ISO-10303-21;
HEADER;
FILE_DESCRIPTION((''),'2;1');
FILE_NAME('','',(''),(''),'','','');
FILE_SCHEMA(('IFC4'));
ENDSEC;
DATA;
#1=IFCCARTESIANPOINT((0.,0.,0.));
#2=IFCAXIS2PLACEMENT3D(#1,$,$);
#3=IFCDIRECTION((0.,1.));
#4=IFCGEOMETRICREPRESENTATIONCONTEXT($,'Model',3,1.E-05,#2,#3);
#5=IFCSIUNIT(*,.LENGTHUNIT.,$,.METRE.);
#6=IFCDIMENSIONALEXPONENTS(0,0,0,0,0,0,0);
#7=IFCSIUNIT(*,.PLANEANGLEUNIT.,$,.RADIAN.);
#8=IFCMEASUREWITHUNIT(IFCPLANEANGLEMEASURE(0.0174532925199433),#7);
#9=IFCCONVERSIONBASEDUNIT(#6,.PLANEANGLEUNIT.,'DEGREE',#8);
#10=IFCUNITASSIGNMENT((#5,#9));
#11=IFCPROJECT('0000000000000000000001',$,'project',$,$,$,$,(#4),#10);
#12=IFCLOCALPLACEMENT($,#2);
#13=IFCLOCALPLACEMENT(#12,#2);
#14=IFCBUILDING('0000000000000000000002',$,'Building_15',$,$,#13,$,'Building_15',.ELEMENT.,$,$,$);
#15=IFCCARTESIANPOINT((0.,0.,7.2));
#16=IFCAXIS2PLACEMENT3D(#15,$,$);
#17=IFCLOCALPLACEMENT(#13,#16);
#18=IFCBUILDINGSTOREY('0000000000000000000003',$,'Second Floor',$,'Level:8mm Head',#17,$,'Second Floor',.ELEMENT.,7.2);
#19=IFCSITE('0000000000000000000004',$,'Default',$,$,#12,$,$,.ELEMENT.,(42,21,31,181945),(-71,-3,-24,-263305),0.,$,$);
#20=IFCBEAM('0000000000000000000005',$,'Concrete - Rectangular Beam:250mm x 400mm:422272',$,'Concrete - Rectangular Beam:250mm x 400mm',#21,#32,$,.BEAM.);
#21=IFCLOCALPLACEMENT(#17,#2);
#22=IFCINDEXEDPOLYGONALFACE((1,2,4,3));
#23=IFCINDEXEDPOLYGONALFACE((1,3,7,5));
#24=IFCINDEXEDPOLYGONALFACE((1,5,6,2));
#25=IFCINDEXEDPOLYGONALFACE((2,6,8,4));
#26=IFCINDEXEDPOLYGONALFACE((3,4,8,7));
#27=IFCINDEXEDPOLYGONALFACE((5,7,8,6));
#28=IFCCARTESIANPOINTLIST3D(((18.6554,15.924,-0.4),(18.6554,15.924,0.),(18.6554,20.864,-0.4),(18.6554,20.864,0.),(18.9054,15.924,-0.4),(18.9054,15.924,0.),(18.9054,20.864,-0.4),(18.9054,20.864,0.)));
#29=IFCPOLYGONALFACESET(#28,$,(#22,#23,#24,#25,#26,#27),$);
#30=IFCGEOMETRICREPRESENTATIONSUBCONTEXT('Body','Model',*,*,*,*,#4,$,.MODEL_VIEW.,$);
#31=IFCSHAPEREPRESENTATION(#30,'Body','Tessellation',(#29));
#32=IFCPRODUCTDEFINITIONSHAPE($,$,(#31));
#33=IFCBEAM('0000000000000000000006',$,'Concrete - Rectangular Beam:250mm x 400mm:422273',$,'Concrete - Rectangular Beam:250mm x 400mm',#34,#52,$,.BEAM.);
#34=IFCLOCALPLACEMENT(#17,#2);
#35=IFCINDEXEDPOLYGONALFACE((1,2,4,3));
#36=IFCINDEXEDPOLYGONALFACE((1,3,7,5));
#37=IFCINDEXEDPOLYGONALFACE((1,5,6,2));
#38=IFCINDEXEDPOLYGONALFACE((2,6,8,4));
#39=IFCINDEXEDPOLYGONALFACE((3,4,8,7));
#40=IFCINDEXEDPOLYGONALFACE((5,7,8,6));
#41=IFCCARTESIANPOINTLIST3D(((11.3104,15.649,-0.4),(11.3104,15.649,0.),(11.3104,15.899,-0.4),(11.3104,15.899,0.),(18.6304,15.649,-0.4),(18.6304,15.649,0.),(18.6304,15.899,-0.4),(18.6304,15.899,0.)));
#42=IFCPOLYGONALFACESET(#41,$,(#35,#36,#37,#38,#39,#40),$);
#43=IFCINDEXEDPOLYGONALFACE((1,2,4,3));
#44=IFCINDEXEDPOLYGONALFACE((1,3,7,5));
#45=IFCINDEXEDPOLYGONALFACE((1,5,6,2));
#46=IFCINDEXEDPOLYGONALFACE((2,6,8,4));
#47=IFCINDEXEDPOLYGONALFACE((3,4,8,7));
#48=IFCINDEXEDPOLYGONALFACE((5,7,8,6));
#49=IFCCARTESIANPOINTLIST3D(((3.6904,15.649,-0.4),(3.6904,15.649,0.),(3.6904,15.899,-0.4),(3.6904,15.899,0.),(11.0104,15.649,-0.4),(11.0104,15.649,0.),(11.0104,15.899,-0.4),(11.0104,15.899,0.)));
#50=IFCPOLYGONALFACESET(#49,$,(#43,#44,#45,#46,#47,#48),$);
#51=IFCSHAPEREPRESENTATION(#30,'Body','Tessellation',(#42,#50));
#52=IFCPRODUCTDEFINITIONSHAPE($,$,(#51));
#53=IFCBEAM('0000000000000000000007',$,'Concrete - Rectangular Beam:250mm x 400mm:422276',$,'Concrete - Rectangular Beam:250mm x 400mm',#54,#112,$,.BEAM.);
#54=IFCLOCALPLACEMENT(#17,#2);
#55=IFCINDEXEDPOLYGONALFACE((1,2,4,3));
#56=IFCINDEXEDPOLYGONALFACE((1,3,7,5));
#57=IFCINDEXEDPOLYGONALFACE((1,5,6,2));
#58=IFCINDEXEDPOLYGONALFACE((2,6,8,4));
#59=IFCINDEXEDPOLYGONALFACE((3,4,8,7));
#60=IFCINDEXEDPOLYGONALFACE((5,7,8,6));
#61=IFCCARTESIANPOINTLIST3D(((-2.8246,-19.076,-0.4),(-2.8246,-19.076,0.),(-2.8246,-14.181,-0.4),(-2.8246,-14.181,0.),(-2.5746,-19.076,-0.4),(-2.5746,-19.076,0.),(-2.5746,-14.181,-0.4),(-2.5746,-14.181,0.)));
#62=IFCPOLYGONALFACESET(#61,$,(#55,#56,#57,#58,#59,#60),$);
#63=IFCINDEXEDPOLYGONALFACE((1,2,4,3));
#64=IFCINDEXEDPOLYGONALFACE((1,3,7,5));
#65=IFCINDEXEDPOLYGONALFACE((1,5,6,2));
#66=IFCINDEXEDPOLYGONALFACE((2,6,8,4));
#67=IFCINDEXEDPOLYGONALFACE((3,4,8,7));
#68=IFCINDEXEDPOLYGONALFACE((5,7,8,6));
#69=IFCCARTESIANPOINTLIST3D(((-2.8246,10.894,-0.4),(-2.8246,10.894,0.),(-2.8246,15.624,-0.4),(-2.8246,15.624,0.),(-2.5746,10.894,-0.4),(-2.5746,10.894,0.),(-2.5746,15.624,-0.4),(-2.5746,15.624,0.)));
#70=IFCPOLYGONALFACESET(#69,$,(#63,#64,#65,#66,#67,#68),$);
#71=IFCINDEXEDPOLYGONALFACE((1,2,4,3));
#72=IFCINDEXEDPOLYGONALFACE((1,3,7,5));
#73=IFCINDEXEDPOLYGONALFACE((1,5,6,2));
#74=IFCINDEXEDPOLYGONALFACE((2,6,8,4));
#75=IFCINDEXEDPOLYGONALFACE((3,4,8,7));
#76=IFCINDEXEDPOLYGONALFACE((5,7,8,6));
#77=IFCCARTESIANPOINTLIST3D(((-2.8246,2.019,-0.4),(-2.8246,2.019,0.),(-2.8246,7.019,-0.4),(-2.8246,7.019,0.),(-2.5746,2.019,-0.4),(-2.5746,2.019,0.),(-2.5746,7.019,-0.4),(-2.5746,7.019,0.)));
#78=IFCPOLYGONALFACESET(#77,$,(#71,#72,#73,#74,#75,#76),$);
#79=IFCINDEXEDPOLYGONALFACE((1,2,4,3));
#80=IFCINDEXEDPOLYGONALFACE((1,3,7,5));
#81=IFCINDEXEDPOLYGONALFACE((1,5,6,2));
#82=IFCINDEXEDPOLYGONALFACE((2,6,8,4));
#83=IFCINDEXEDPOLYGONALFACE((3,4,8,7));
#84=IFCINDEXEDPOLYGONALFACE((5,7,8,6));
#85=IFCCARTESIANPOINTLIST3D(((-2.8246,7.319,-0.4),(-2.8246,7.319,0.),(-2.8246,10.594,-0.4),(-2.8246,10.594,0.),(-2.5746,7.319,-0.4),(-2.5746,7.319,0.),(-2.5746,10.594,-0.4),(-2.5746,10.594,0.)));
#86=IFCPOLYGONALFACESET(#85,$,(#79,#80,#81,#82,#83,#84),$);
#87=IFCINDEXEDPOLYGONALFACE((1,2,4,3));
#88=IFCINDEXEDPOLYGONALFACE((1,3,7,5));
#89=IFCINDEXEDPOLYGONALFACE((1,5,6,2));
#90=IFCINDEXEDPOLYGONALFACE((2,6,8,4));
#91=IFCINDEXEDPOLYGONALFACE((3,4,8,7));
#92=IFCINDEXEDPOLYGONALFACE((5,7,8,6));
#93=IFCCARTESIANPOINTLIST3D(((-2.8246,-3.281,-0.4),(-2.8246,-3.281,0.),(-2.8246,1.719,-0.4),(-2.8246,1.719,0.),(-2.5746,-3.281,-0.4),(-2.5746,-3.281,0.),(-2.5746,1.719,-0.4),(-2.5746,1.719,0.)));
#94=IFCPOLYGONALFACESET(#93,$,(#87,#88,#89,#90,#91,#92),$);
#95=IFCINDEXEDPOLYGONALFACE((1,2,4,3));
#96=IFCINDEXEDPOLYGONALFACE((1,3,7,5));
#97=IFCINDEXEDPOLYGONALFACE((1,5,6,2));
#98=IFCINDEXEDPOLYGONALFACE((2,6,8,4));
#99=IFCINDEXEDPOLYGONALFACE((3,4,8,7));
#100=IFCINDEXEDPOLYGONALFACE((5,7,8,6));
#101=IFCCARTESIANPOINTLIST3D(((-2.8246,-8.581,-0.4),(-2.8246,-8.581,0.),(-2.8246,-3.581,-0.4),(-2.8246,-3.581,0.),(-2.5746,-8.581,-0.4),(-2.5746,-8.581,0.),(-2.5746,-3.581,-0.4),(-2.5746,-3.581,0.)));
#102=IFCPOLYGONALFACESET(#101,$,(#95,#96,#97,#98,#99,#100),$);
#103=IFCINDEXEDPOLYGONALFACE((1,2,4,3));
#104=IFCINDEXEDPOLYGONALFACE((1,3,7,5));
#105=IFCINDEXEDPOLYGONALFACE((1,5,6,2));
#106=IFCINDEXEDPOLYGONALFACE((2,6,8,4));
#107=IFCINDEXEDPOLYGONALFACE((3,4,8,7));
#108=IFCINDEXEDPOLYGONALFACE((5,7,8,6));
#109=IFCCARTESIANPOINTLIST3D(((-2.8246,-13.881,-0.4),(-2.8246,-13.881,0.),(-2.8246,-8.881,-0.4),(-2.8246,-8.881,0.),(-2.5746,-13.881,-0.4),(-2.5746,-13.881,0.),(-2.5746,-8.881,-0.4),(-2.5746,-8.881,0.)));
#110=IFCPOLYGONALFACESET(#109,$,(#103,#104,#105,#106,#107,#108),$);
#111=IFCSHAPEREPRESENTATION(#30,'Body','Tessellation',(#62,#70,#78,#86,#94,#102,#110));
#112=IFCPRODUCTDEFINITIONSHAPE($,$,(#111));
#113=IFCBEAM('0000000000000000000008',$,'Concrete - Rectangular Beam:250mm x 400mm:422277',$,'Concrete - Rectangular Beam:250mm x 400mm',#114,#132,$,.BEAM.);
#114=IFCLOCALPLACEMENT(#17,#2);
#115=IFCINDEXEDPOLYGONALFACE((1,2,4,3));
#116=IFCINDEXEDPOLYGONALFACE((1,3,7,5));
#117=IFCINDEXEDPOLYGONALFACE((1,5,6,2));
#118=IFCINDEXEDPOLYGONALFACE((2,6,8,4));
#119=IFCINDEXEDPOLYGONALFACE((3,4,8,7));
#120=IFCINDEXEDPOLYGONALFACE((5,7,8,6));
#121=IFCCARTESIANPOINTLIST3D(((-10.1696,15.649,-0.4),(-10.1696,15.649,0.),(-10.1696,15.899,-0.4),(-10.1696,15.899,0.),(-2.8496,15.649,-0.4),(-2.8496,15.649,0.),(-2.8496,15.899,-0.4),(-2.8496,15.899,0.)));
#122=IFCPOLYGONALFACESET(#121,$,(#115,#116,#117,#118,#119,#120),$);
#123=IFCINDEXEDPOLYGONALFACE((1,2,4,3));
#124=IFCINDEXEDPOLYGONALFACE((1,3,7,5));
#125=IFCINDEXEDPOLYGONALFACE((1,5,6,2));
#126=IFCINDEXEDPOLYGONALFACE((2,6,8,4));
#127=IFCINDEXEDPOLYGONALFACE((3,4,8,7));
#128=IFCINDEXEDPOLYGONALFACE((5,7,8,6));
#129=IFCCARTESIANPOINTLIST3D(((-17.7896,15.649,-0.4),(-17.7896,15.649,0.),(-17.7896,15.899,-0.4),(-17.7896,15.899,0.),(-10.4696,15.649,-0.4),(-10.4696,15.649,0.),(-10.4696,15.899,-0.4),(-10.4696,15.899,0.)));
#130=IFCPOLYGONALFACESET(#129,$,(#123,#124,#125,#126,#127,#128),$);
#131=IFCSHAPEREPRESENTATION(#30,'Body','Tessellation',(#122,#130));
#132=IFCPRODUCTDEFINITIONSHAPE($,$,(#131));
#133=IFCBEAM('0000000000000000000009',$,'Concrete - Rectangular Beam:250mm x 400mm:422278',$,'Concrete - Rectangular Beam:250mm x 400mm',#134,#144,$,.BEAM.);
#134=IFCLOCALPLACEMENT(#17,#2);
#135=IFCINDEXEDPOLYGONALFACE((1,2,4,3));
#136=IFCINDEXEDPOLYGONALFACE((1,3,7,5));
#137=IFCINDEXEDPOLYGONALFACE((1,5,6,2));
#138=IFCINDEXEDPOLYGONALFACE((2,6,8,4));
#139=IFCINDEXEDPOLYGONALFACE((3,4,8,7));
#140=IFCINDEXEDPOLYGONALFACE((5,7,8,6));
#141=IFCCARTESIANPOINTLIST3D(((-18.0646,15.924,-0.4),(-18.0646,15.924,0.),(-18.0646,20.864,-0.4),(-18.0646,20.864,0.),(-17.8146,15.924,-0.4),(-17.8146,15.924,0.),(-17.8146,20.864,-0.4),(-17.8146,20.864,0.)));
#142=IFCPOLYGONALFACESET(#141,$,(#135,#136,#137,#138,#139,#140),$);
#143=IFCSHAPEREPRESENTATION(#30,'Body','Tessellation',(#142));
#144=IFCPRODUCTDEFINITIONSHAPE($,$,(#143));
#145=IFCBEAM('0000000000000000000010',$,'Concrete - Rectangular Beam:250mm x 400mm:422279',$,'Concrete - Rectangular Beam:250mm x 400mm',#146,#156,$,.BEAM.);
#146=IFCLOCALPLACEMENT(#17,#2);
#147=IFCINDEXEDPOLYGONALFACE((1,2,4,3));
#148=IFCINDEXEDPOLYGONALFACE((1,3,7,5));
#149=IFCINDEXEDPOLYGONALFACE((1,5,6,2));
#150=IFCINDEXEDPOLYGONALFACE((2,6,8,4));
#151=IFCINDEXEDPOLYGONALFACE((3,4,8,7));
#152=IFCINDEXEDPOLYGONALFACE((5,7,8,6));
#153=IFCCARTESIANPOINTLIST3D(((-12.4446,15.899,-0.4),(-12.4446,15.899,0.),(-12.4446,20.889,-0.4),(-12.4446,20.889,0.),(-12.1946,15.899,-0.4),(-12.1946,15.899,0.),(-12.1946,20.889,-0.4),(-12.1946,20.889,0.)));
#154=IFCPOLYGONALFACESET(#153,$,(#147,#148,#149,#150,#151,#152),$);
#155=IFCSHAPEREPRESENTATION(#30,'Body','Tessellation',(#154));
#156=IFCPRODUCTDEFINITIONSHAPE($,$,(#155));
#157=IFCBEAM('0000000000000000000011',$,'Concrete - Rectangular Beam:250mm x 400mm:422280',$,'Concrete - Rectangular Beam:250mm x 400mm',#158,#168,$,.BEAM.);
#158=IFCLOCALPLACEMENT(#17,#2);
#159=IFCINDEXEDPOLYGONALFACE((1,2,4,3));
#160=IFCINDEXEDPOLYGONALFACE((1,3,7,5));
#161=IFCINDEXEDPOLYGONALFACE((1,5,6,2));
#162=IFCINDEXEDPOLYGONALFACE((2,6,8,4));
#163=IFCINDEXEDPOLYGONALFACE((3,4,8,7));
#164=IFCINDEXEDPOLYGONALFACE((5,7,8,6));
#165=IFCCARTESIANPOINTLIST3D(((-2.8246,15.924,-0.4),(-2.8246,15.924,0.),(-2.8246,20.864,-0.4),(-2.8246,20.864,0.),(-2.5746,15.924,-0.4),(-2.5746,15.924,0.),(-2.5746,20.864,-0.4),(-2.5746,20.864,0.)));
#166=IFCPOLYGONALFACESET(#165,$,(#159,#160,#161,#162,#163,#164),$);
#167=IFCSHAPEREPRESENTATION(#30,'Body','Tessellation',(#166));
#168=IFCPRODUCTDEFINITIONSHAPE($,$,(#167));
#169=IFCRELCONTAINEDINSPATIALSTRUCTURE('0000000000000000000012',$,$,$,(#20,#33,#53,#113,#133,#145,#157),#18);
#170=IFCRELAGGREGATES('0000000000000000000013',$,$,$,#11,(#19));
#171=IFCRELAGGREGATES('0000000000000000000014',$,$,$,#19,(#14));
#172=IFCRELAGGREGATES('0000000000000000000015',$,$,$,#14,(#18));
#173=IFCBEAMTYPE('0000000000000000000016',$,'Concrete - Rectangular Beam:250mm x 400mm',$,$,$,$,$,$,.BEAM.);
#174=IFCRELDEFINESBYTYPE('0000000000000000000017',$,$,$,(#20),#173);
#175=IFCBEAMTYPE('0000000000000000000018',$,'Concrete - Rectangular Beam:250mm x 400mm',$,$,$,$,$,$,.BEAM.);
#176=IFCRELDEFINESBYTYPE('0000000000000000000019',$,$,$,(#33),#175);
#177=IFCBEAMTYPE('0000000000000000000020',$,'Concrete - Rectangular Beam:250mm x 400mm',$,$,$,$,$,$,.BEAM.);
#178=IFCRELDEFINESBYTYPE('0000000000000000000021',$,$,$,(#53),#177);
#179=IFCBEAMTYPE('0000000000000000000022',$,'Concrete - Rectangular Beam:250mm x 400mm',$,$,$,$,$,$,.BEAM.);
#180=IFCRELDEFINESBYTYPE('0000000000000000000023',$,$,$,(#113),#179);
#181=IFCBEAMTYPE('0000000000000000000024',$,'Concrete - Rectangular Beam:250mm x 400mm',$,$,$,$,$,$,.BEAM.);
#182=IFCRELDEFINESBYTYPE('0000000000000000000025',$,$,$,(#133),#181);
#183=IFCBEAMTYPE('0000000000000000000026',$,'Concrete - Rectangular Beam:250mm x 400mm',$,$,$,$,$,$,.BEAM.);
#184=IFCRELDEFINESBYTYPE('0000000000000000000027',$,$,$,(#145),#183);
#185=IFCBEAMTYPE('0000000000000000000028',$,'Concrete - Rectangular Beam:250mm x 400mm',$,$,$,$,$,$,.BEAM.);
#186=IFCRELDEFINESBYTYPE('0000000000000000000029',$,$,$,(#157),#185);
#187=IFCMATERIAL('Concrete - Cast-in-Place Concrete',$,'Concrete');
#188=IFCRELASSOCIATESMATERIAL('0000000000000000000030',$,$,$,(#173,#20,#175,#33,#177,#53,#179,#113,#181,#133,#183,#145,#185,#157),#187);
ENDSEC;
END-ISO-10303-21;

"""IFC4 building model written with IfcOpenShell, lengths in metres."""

from ifc_helpers import new_model, entity, si_unit, converted_unit, direction, frame, origin, place, context, subcontext, project, spatial, indexed_curve, outline, extrude, source, transform, mapped, material, type_object, type_shapes, element, save


model = new_model("IFC4")

# Units and contexts
model_context = context("Model", 3, precision=1e-05, world=origin(), true_north=direction((0.0, 1.0)))
body_context = subcontext(model_context, "Body", "Model", "MODEL_VIEW")
ifc_project = project(units=[si_unit("LENGTHUNIT", "METRE"), converted_unit("PLANEANGLEUNIT", "DEGREE", entity("IfcPlaneAngleMeasure", 0.0174532925199433), si_unit("PLANEANGLEUNIT", "RADIAN"), dimensions=[0, 0, 0, 0, 0, 0, 0])], contexts=[model_context])

# Site, building, storey
site_placement = place(None, origin())
site = spatial("IfcSite", under=ifc_project, at=site_placement, Name="Default", CompositionType="ELEMENT", RefLatitude=(42, 21, 31, 181945), RefLongitude=(-71, -3, -24, -263305), RefElevation=0.0)
building_placement = place(site_placement, origin())
building = spatial("IfcBuilding", under=site, at=building_placement, Name="Building_15", LongName="Building_15", CompositionType="ELEMENT")
storey_placement = place(building_placement, frame((0.0, 0.0, 7.2)))
storey = spatial("IfcBuildingStorey", under=building, at=storey_placement, Name="Second Floor", ObjectType="Level:8mm Head", LongName="Second Floor", CompositionType="ELEMENT", Elevation=7.2)

# Shared definitions
ifc_material_1 = material(Name="Concrete - Cast-in-Place Concrete", Category="Concrete")

# Beams
beam_type_1 = type_object("IfcBeamType", Name="Concrete - Rectangular Beam:250mm x 400mm", PredefinedType="BEAM", material=ifc_material_1)
shared_shape_1 = source(origin(), body_context, "Body", "SweptSolid", [
    extrude(outline(indexed_curve([(-0.125, -0.2), (0.125, -0.2), (0.125, 0.2), (-0.125, 0.2), (-0.125, -0.2)], self_intersect=False)), frame((18.7804, 20.864, 7.0), z_axis=(0.0, -1.0, 0.0), x_axis=(-1.0, 0.0, 0.0)), (0.0, 0.0, 1.0), 4.94),
])
type_shapes(beam_type_1, [shared_shape_1])
beam_1_placement = place(storey_placement, frame((0.0, 0.0, -7.2)))
element("IfcBeam", 1, at=beam_1_placement, inside=storey, type_object=beam_type_1, material=ifc_material_1, Name="Concrete - Rectangular Beam:250mm x 400mm:422272", ObjectType="Concrete - Rectangular Beam:250mm x 400mm", PredefinedType="BEAM", context=body_context, shape_type="MappedRepresentation", body=[
    mapped(shared_shape_1, transform((0.0, 0.0, 0.0), scale=1.0)),
])
beam_type_2 = type_object("IfcBeamType", Name="Concrete - Rectangular Beam:250mm x 400mm", PredefinedType="BEAM", material=ifc_material_1)
shared_shape_2 = source(origin(), body_context, "Body", "SweptSolid", [
    extrude(outline(indexed_curve([(-0.2, -0.125), (0.2, -0.125), (0.2, 0.125), (-0.2, 0.125), (-0.2, -0.125)], self_intersect=False)), frame((18.6304, 15.774, 7.0), z_axis=(-1.0, 0.0, 0.0), x_axis=(0.0, 0.0, -1.0)), (0.0, 0.0, 1.0), 7.32),
    extrude(outline(indexed_curve([(-0.2, -0.125), (0.2, -0.125), (0.2, 0.125), (-0.2, 0.125), (-0.2, -0.125)], self_intersect=False)), frame((11.0104, 15.774, 7.0), z_axis=(-1.0, 0.0, 0.0), x_axis=(0.0, 0.0, -1.0)), (0.0, 0.0, 1.0), 7.32),
])
type_shapes(beam_type_2, [shared_shape_2])
beam_2_placement = place(storey_placement, frame((0.0, 0.0, -7.2)))
element("IfcBeam", 2, at=beam_2_placement, inside=storey, type_object=beam_type_2, material=ifc_material_1, Name="Concrete - Rectangular Beam:250mm x 400mm:422273", ObjectType="Concrete - Rectangular Beam:250mm x 400mm", PredefinedType="BEAM", context=body_context, shape_type="MappedRepresentation", body=[
    mapped(shared_shape_2, transform((0.0, 0.0, 0.0), scale=1.0)),
])
beam_type_3 = type_object("IfcBeamType", Name="Concrete - Rectangular Beam:250mm x 400mm", PredefinedType="BEAM", material=ifc_material_1)
shared_shape_3 = source(origin(), body_context, "Body", "SweptSolid", [
    extrude(outline(indexed_curve([(-0.125, -0.2), (0.125, -0.2), (0.125, 0.2), (-0.125, 0.2), (-0.125, -0.2)], self_intersect=False)), frame((-2.6996, -19.076, 7.0), z_axis=(0.0, 1.0, 0.0), x_axis=(-1.0, 0.0, 0.0)), (0.0, 0.0, 1.0), 4.895),
    extrude(outline(indexed_curve([(-0.125, -0.2), (0.125, -0.2), (0.125, 0.2), (-0.125, 0.2), (-0.125, -0.2)], self_intersect=False)), frame((-2.6996, 10.894, 7.0), z_axis=(0.0, 1.0, 0.0), x_axis=(-1.0, 0.0, 0.0)), (0.0, 0.0, 1.0), 4.73),
    extrude(outline(indexed_curve([(-0.125, -0.2), (0.125, -0.2), (0.125, 0.2), (-0.125, 0.2), (-0.125, -0.2)], self_intersect=False)), frame((-2.6996, 2.019, 7.0), z_axis=(0.0, 1.0, 0.0), x_axis=(-1.0, 0.0, 0.0)), (0.0, 0.0, 1.0), 5.0),
    extrude(outline(indexed_curve([(-0.125, -0.2), (0.125, -0.2), (0.125, 0.2), (-0.125, 0.2), (-0.125, -0.2)], self_intersect=False)), frame((-2.6996, 7.319, 7.0), z_axis=(0.0, 1.0, 0.0), x_axis=(-1.0, 0.0, 0.0)), (0.0, 0.0, 1.0), 3.275),
    extrude(outline(indexed_curve([(-0.125, -0.2), (0.125, -0.2), (0.125, 0.2), (-0.125, 0.2), (-0.125, -0.2)], self_intersect=False)), frame((-2.6996, -3.281, 7.0), z_axis=(0.0, 1.0, 0.0), x_axis=(-1.0, 0.0, 0.0)), (0.0, 0.0, 1.0), 5.0),
    extrude(outline(indexed_curve([(-0.125, -0.2), (0.125, -0.2), (0.125, 0.2), (-0.125, 0.2), (-0.125, -0.2)], self_intersect=False)), frame((-2.6996, -8.581, 7.0), z_axis=(0.0, 1.0, 0.0), x_axis=(-1.0, 0.0, 0.0)), (0.0, 0.0, 1.0), 5.0),
    extrude(outline(indexed_curve([(-0.125, -0.2), (0.125, -0.2), (0.125, 0.2), (-0.125, 0.2), (-0.125, -0.2)], self_intersect=False)), frame((-2.6996, -13.881, 7.0), z_axis=(0.0, 1.0, 0.0), x_axis=(-1.0, 0.0, 0.0)), (0.0, 0.0, 1.0), 5.0),
])
type_shapes(beam_type_3, [shared_shape_3])
beam_3_placement = place(storey_placement, frame((0.0, 0.0, -7.2)))
element("IfcBeam", 3, at=beam_3_placement, inside=storey, type_object=beam_type_3, material=ifc_material_1, Name="Concrete - Rectangular Beam:250mm x 400mm:422276", ObjectType="Concrete - Rectangular Beam:250mm x 400mm", PredefinedType="BEAM", context=body_context, shape_type="MappedRepresentation", body=[
    mapped(shared_shape_3, transform((0.0, 0.0, 0.0), scale=1.0)),
])
beam_type_4 = type_object("IfcBeamType", Name="Concrete - Rectangular Beam:250mm x 400mm", PredefinedType="BEAM", material=ifc_material_1)
shared_shape_4 = source(origin(), body_context, "Body", "SweptSolid", [
    extrude(outline(indexed_curve([(-0.2, -0.125), (0.2, -0.125), (0.2, 0.125), (-0.2, 0.125), (-0.2, -0.125)], self_intersect=False)), frame((-2.8496, 15.774, 7.0), z_axis=(-1.0, 0.0, 0.0), x_axis=(0.0, 0.0, -1.0)), (0.0, 0.0, 1.0), 7.32),
    extrude(outline(indexed_curve([(-0.2, -0.125), (0.2, -0.125), (0.2, 0.125), (-0.2, 0.125), (-0.2, -0.125)], self_intersect=False)), frame((-10.4696, 15.774, 7.0), z_axis=(-1.0, 0.0, 0.0), x_axis=(0.0, 0.0, -1.0)), (0.0, 0.0, 1.0), 7.32),
])
type_shapes(beam_type_4, [shared_shape_4])
beam_4_placement = place(storey_placement, frame((0.0, 0.0, -7.2)))
element("IfcBeam", 4, at=beam_4_placement, inside=storey, type_object=beam_type_4, material=ifc_material_1, Name="Concrete - Rectangular Beam:250mm x 400mm:422277", ObjectType="Concrete - Rectangular Beam:250mm x 400mm", PredefinedType="BEAM", context=body_context, shape_type="MappedRepresentation", body=[
    mapped(shared_shape_4, transform((0.0, 0.0, 0.0), scale=1.0)),
])
beam_type_5 = type_object("IfcBeamType", Name="Concrete - Rectangular Beam:250mm x 400mm", PredefinedType="BEAM", material=ifc_material_1)
shared_shape_5 = source(origin(), body_context, "Body", "SweptSolid", [
    extrude(outline(indexed_curve([(-0.125, -0.2), (0.125, -0.2), (0.125, 0.2), (-0.125, 0.2), (-0.125, -0.2)], self_intersect=False)), frame((-17.9396, 15.924, 7.0), z_axis=(0.0, 1.0, 0.0), x_axis=(-1.0, 0.0, 0.0)), (0.0, 0.0, 1.0), 4.94),
])
type_shapes(beam_type_5, [shared_shape_5])
beam_5_placement = place(storey_placement, frame((0.0, 0.0, -7.2)))
element("IfcBeam", 5, at=beam_5_placement, inside=storey, type_object=beam_type_5, material=ifc_material_1, Name="Concrete - Rectangular Beam:250mm x 400mm:422278", ObjectType="Concrete - Rectangular Beam:250mm x 400mm", PredefinedType="BEAM", context=body_context, shape_type="MappedRepresentation", body=[
    mapped(shared_shape_5, transform((0.0, 0.0, 0.0), scale=1.0)),
])
beam_type_6 = type_object("IfcBeamType", Name="Concrete - Rectangular Beam:250mm x 400mm", PredefinedType="BEAM", material=ifc_material_1)
shared_shape_6 = source(origin(), body_context, "Body", "SweptSolid", [
    extrude(outline(indexed_curve([(-0.125, -0.2), (0.125, -0.2), (0.125, 0.2), (-0.125, 0.2), (-0.125, -0.2)], self_intersect=False)), frame((-12.3196, 20.889, 7.0), z_axis=(0.0, -1.0, 0.0), x_axis=(-1.0, 0.0, 0.0)), (0.0, 0.0, 1.0), 4.99),
])
type_shapes(beam_type_6, [shared_shape_6])
beam_6_placement = place(storey_placement, frame((0.0, 0.0, -7.2)))
element("IfcBeam", 6, at=beam_6_placement, inside=storey, type_object=beam_type_6, material=ifc_material_1, Name="Concrete - Rectangular Beam:250mm x 400mm:422279", ObjectType="Concrete - Rectangular Beam:250mm x 400mm", PredefinedType="BEAM", context=body_context, shape_type="MappedRepresentation", body=[
    mapped(shared_shape_6, transform((0.0, 0.0, 0.0), scale=1.0)),
])
beam_type_7 = type_object("IfcBeamType", Name="Concrete - Rectangular Beam:250mm x 400mm", PredefinedType="BEAM", material=ifc_material_1)
shared_shape_7 = source(origin(), body_context, "Body", "SweptSolid", [
    extrude(outline(indexed_curve([(-0.125, -0.2), (0.125, -0.2), (0.125, 0.2), (-0.125, 0.2), (-0.125, -0.2)], self_intersect=False)), frame((-2.6996, 20.864, 7.0), z_axis=(0.0, -1.0, 0.0), x_axis=(-1.0, 0.0, 0.0)), (0.0, 0.0, 1.0), 4.94),
])
type_shapes(beam_type_7, [shared_shape_7])
beam_7_placement = place(storey_placement, frame((0.0, 0.0, -7.2)))
element("IfcBeam", 7, at=beam_7_placement, inside=storey, type_object=beam_type_7, material=ifc_material_1, Name="Concrete - Rectangular Beam:250mm x 400mm:422280", ObjectType="Concrete - Rectangular Beam:250mm x 400mm", PredefinedType="BEAM", context=body_context, shape_type="MappedRepresentation", body=[
    mapped(shared_shape_7, transform((0.0, 0.0, 0.0), scale=1.0)),
])

save(model, "model.ifc")
